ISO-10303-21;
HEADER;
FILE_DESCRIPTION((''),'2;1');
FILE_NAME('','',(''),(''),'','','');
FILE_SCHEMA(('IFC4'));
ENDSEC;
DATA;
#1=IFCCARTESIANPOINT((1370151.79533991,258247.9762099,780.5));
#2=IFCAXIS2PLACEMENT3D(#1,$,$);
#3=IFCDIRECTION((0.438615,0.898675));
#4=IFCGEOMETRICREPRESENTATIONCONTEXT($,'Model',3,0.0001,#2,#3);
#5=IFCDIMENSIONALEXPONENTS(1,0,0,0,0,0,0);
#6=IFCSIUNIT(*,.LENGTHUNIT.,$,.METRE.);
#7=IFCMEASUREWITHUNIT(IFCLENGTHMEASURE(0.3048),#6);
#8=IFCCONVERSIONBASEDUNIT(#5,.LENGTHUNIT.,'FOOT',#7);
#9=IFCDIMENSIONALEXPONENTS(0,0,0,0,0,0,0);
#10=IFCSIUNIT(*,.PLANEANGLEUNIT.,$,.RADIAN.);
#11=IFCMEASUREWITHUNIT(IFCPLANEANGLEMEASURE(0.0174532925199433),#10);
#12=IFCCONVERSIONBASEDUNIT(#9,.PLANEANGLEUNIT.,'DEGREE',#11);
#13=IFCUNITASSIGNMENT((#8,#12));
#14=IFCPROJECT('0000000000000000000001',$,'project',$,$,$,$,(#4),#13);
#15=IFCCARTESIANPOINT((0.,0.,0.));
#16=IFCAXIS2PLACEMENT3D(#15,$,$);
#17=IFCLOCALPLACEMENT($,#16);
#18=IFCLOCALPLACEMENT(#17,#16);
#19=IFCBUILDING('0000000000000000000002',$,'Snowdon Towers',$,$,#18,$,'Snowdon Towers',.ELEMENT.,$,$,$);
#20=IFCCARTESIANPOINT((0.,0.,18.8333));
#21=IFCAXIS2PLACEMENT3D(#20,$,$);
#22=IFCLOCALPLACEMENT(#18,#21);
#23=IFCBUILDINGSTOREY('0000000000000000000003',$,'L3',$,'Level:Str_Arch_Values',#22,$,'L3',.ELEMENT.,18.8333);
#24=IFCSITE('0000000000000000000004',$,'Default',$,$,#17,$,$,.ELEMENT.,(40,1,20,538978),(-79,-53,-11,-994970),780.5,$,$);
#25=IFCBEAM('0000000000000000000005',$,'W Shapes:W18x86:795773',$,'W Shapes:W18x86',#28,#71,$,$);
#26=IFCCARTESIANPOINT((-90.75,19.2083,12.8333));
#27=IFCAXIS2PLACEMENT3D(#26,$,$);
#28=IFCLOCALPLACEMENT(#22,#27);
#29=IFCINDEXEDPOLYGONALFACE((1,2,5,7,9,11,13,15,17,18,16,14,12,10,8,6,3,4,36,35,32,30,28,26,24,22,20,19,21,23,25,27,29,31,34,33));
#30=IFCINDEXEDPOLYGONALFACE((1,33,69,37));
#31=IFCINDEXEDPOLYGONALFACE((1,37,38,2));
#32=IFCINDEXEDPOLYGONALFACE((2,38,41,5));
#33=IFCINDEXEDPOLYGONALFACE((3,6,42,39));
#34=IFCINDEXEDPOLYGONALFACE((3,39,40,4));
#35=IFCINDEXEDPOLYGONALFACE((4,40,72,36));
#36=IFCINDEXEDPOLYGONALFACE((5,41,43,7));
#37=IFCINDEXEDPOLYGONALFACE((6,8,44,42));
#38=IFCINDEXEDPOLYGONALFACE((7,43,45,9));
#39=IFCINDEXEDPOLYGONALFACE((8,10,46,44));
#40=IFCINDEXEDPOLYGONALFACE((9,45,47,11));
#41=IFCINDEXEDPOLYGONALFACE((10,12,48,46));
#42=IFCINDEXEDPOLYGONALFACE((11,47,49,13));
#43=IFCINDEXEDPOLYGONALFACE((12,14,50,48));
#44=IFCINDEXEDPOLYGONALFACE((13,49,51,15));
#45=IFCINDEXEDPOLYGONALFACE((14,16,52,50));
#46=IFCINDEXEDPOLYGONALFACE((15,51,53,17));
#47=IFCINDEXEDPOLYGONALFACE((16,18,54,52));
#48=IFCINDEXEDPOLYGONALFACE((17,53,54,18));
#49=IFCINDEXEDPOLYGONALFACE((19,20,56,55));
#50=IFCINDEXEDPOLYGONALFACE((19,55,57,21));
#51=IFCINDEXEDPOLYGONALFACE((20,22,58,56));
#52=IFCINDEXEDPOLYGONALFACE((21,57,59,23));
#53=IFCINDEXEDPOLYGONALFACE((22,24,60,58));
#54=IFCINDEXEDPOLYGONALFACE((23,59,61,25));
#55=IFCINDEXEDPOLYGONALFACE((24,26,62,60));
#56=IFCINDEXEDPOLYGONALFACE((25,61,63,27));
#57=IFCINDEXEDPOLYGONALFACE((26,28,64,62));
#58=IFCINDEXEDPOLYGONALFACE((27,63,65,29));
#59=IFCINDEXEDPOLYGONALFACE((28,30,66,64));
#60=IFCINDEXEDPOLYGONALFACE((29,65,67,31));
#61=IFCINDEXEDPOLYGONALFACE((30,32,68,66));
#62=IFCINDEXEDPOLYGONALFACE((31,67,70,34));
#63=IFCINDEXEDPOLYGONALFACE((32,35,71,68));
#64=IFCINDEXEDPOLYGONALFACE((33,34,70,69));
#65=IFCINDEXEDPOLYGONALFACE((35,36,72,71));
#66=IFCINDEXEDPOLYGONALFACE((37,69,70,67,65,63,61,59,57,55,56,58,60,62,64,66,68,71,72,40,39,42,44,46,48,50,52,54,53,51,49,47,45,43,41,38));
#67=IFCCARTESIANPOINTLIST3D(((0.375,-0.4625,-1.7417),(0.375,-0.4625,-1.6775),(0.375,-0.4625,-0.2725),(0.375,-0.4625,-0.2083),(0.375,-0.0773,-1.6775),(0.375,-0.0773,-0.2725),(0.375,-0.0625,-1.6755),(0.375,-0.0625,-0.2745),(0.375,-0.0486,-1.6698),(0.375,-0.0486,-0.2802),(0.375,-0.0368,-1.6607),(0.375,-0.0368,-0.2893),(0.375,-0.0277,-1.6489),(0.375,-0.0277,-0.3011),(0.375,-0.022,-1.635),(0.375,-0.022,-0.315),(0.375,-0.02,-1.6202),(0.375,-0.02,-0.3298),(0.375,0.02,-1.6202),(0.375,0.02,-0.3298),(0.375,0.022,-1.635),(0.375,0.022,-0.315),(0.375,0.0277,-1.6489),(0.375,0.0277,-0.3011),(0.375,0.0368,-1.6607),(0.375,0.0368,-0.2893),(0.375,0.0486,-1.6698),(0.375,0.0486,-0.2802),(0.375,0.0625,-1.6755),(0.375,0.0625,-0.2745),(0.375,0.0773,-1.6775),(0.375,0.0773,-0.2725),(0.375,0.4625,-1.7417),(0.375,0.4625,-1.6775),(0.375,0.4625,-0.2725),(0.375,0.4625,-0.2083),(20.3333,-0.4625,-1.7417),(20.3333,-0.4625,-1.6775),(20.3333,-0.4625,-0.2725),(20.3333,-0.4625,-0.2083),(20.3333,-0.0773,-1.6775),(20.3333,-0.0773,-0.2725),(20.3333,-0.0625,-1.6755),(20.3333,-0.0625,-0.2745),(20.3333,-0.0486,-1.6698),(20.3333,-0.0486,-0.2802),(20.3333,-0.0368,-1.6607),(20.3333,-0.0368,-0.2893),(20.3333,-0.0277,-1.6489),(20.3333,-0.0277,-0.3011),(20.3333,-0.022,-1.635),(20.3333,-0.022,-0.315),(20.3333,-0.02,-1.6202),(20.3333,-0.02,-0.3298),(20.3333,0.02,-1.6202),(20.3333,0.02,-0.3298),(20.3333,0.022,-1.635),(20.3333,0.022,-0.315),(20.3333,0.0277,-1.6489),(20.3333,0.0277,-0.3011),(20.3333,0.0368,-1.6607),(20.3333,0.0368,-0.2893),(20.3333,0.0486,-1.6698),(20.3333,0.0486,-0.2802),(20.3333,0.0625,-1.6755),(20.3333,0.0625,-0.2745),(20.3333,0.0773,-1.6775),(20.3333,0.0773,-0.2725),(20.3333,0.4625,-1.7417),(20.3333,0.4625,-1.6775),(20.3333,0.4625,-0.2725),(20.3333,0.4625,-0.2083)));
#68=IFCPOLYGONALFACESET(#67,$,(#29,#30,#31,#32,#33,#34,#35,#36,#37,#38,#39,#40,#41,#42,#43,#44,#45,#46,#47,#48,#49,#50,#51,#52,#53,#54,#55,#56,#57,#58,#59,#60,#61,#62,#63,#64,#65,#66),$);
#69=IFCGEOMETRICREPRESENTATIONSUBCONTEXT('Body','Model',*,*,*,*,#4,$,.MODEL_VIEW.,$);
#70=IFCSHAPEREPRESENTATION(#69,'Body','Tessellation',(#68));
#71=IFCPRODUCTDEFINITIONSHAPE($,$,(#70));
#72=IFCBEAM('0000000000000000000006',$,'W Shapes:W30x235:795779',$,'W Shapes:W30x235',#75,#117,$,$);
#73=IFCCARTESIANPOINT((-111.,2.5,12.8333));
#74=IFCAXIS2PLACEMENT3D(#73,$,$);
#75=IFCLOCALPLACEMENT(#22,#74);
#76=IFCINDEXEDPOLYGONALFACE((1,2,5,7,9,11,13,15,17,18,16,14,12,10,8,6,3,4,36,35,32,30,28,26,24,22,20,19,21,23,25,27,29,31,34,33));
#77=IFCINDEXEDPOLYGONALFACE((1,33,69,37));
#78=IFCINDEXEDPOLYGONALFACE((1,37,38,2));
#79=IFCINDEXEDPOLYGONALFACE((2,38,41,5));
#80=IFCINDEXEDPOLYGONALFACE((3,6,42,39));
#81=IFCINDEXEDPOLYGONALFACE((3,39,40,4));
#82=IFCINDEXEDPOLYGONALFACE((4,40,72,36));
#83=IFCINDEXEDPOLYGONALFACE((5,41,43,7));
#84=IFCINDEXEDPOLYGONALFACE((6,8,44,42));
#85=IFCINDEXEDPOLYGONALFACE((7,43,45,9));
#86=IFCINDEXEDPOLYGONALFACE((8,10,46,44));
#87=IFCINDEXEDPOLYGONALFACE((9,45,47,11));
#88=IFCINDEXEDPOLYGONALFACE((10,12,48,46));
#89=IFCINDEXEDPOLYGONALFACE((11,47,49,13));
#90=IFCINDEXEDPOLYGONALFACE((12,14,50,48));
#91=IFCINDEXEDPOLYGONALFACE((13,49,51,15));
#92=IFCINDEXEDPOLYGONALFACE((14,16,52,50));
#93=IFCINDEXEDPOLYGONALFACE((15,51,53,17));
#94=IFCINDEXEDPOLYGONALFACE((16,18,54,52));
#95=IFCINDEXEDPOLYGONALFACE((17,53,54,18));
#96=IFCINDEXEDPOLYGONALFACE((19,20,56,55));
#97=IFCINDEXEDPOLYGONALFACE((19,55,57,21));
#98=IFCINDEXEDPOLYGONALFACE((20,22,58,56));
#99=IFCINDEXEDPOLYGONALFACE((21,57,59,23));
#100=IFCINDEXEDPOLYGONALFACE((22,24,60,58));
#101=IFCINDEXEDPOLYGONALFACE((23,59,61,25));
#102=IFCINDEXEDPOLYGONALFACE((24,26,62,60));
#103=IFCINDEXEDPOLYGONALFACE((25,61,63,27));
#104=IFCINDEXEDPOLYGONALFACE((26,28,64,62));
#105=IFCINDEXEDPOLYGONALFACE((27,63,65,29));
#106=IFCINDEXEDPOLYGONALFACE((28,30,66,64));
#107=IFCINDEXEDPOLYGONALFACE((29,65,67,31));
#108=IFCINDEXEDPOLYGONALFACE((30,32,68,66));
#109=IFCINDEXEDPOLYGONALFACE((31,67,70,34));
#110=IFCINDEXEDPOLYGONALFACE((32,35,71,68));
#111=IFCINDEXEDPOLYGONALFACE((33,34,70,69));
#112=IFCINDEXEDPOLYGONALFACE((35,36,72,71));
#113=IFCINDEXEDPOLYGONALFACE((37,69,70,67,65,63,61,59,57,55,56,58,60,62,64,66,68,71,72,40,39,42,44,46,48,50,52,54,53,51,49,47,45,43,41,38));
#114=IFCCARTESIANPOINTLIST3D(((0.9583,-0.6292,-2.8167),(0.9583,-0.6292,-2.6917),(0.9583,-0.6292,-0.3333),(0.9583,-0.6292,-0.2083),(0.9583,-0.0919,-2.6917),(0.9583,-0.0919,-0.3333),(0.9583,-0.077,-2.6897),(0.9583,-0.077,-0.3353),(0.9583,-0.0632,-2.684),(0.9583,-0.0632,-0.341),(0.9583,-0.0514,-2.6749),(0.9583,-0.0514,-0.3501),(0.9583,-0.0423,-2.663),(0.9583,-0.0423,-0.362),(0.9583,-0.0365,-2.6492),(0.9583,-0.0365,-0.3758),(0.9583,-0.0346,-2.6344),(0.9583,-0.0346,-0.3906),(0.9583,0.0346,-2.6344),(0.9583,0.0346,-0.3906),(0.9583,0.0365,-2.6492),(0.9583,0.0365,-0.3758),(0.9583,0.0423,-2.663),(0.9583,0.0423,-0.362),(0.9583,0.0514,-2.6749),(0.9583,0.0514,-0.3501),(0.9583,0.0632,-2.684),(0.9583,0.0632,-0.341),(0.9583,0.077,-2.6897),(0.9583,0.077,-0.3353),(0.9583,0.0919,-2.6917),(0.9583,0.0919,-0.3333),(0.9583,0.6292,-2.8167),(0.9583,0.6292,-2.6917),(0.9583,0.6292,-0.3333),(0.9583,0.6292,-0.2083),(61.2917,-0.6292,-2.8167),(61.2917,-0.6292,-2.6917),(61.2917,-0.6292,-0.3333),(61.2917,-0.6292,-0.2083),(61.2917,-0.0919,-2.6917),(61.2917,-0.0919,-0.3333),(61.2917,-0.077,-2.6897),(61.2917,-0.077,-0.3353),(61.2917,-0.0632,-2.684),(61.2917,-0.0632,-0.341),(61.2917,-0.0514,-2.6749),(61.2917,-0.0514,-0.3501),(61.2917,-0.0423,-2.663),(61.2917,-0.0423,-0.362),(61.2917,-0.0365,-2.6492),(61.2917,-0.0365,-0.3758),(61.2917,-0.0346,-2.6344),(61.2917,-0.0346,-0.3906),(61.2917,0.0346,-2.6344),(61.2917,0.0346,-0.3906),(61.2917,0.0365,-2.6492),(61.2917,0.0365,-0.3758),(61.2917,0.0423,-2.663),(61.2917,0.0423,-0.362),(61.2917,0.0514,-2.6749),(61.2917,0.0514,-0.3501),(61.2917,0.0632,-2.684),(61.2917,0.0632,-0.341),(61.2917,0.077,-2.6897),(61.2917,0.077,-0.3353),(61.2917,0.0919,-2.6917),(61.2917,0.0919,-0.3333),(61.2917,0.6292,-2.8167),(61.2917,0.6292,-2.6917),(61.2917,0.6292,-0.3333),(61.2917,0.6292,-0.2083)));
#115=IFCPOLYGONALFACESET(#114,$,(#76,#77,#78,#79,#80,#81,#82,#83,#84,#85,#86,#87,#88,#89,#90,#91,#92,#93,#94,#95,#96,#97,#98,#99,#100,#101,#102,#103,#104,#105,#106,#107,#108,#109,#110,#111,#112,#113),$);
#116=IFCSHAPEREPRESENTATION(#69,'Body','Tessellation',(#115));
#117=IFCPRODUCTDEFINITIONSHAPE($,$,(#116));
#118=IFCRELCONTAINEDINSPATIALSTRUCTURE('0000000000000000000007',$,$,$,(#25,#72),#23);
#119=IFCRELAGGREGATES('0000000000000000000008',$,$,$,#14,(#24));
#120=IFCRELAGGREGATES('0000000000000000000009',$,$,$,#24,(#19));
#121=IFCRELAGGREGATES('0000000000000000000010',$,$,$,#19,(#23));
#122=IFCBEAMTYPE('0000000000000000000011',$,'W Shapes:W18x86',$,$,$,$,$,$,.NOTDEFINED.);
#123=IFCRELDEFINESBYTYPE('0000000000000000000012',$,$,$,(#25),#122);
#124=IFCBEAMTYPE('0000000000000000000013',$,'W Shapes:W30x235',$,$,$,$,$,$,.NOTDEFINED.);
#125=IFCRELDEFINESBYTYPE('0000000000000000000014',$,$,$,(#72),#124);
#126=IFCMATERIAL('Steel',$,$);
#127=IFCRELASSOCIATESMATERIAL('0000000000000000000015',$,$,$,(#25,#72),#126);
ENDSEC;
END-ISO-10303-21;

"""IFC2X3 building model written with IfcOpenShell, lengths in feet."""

from ifc_helpers import new_model, entity, si_unit, converted_unit, direction, frame, frame_2d, origin, place, context, subcontext, project, spatial, i_section, extrude, material, type_object, element, save


model = new_model("IFC2X3")

# Units and contexts
model_context = context("Model", 3, precision=0.0001, world=frame((1370151.79533991, 258247.9762099, 780.5)), true_north=direction((0.438615, 0.898675)))
body_context = subcontext(model_context, "Body", "Model", "MODEL_VIEW")
ifc_project = project(units=[converted_unit("LENGTHUNIT", "FOOT", entity("IfcLengthMeasure", 0.3048), si_unit("LENGTHUNIT", "METRE"), dimensions=[1, 0, 0, 0, 0, 0, 0]), converted_unit("PLANEANGLEUNIT", "DEGREE", entity("IfcPlaneAngleMeasure", 0.0174532925199433), si_unit("PLANEANGLEUNIT", "RADIAN"), dimensions=[0, 0, 0, 0, 0, 0, 0])], contexts=[model_context])

# Site, building, storey
site_placement = place(None, origin())
site = spatial("IfcSite", under=ifc_project, at=site_placement, Name="Default", CompositionType="ELEMENT", RefLatitude=(40, 1, 20, 538978), RefLongitude=(-79, -53, -11, -994970), RefElevation=780.5)
building_placement = place(site_placement, origin())
building = spatial("IfcBuilding", under=site, at=building_placement, Name="Snowdon Towers", LongName="Snowdon Towers", CompositionType="ELEMENT")
storey_placement = place(building_placement, frame((0.0, 0.0, 18.8333)))
storey = spatial("IfcBuildingStorey", under=building, at=storey_placement, Name="L3", ObjectType="Level:Str_Arch_Values", LongName="L3", CompositionType="ELEMENT", Elevation=18.8333)

# Shared definitions
ifc_material_1 = material(Name="Steel")

# Beams
beam_type_1 = type_object("IfcBeamType", Name="W Shapes:W18x86", PredefinedType="NOTDEFINED")
beam_1_placement = place(storey_placement, frame((-90.75, 19.2083, 12.8333)))
element("IfcBeam", 1, at=beam_1_placement, inside=storey, type_object=beam_type_1, material=ifc_material_1, Name="W Shapes:W18x86:795773", ObjectType="W Shapes:W18x86", context=body_context, shape_type="SweptSolid", body=[
    extrude(i_section(OverallWidth=0.925, OverallDepth=1.5333, WebThickness=0.04, FlangeThickness=0.0642, FilletRadius=0.0573, at=frame_2d((0.0, 0.0), x_axis=(0.0, 1.0))), frame((0.375, 0.0, -0.975), z_axis=(1.0, 0.0, 0.0), x_axis=(0.0, 0.0, -1.0)), (0.0, 0.0, 1.0), 19.9583),
])
beam_type_2 = type_object("IfcBeamType", Name="W Shapes:W30x235", PredefinedType="NOTDEFINED")
beam_2_placement = place(storey_placement, frame((-111.0, 2.5, 12.8333)))
element("IfcBeam", 2, at=beam_2_placement, inside=storey, type_object=beam_type_2, material=ifc_material_1, Name="W Shapes:W30x235:795779", ObjectType="W Shapes:W30x235", context=body_context, shape_type="SweptSolid", body=[
    extrude(i_section(OverallWidth=1.2583, OverallDepth=2.6083, WebThickness=0.0692, FlangeThickness=0.125, FilletRadius=0.0573, at=frame_2d((0.0, 0.0), x_axis=(0.0, 1.0))), frame((0.9583, 0.0, -1.5125), z_axis=(1.0, 0.0, 0.0), x_axis=(0.0, 0.0, -1.0)), (0.0, 0.0, 1.0), 60.3333),
])

save(model, "model.ifc")
